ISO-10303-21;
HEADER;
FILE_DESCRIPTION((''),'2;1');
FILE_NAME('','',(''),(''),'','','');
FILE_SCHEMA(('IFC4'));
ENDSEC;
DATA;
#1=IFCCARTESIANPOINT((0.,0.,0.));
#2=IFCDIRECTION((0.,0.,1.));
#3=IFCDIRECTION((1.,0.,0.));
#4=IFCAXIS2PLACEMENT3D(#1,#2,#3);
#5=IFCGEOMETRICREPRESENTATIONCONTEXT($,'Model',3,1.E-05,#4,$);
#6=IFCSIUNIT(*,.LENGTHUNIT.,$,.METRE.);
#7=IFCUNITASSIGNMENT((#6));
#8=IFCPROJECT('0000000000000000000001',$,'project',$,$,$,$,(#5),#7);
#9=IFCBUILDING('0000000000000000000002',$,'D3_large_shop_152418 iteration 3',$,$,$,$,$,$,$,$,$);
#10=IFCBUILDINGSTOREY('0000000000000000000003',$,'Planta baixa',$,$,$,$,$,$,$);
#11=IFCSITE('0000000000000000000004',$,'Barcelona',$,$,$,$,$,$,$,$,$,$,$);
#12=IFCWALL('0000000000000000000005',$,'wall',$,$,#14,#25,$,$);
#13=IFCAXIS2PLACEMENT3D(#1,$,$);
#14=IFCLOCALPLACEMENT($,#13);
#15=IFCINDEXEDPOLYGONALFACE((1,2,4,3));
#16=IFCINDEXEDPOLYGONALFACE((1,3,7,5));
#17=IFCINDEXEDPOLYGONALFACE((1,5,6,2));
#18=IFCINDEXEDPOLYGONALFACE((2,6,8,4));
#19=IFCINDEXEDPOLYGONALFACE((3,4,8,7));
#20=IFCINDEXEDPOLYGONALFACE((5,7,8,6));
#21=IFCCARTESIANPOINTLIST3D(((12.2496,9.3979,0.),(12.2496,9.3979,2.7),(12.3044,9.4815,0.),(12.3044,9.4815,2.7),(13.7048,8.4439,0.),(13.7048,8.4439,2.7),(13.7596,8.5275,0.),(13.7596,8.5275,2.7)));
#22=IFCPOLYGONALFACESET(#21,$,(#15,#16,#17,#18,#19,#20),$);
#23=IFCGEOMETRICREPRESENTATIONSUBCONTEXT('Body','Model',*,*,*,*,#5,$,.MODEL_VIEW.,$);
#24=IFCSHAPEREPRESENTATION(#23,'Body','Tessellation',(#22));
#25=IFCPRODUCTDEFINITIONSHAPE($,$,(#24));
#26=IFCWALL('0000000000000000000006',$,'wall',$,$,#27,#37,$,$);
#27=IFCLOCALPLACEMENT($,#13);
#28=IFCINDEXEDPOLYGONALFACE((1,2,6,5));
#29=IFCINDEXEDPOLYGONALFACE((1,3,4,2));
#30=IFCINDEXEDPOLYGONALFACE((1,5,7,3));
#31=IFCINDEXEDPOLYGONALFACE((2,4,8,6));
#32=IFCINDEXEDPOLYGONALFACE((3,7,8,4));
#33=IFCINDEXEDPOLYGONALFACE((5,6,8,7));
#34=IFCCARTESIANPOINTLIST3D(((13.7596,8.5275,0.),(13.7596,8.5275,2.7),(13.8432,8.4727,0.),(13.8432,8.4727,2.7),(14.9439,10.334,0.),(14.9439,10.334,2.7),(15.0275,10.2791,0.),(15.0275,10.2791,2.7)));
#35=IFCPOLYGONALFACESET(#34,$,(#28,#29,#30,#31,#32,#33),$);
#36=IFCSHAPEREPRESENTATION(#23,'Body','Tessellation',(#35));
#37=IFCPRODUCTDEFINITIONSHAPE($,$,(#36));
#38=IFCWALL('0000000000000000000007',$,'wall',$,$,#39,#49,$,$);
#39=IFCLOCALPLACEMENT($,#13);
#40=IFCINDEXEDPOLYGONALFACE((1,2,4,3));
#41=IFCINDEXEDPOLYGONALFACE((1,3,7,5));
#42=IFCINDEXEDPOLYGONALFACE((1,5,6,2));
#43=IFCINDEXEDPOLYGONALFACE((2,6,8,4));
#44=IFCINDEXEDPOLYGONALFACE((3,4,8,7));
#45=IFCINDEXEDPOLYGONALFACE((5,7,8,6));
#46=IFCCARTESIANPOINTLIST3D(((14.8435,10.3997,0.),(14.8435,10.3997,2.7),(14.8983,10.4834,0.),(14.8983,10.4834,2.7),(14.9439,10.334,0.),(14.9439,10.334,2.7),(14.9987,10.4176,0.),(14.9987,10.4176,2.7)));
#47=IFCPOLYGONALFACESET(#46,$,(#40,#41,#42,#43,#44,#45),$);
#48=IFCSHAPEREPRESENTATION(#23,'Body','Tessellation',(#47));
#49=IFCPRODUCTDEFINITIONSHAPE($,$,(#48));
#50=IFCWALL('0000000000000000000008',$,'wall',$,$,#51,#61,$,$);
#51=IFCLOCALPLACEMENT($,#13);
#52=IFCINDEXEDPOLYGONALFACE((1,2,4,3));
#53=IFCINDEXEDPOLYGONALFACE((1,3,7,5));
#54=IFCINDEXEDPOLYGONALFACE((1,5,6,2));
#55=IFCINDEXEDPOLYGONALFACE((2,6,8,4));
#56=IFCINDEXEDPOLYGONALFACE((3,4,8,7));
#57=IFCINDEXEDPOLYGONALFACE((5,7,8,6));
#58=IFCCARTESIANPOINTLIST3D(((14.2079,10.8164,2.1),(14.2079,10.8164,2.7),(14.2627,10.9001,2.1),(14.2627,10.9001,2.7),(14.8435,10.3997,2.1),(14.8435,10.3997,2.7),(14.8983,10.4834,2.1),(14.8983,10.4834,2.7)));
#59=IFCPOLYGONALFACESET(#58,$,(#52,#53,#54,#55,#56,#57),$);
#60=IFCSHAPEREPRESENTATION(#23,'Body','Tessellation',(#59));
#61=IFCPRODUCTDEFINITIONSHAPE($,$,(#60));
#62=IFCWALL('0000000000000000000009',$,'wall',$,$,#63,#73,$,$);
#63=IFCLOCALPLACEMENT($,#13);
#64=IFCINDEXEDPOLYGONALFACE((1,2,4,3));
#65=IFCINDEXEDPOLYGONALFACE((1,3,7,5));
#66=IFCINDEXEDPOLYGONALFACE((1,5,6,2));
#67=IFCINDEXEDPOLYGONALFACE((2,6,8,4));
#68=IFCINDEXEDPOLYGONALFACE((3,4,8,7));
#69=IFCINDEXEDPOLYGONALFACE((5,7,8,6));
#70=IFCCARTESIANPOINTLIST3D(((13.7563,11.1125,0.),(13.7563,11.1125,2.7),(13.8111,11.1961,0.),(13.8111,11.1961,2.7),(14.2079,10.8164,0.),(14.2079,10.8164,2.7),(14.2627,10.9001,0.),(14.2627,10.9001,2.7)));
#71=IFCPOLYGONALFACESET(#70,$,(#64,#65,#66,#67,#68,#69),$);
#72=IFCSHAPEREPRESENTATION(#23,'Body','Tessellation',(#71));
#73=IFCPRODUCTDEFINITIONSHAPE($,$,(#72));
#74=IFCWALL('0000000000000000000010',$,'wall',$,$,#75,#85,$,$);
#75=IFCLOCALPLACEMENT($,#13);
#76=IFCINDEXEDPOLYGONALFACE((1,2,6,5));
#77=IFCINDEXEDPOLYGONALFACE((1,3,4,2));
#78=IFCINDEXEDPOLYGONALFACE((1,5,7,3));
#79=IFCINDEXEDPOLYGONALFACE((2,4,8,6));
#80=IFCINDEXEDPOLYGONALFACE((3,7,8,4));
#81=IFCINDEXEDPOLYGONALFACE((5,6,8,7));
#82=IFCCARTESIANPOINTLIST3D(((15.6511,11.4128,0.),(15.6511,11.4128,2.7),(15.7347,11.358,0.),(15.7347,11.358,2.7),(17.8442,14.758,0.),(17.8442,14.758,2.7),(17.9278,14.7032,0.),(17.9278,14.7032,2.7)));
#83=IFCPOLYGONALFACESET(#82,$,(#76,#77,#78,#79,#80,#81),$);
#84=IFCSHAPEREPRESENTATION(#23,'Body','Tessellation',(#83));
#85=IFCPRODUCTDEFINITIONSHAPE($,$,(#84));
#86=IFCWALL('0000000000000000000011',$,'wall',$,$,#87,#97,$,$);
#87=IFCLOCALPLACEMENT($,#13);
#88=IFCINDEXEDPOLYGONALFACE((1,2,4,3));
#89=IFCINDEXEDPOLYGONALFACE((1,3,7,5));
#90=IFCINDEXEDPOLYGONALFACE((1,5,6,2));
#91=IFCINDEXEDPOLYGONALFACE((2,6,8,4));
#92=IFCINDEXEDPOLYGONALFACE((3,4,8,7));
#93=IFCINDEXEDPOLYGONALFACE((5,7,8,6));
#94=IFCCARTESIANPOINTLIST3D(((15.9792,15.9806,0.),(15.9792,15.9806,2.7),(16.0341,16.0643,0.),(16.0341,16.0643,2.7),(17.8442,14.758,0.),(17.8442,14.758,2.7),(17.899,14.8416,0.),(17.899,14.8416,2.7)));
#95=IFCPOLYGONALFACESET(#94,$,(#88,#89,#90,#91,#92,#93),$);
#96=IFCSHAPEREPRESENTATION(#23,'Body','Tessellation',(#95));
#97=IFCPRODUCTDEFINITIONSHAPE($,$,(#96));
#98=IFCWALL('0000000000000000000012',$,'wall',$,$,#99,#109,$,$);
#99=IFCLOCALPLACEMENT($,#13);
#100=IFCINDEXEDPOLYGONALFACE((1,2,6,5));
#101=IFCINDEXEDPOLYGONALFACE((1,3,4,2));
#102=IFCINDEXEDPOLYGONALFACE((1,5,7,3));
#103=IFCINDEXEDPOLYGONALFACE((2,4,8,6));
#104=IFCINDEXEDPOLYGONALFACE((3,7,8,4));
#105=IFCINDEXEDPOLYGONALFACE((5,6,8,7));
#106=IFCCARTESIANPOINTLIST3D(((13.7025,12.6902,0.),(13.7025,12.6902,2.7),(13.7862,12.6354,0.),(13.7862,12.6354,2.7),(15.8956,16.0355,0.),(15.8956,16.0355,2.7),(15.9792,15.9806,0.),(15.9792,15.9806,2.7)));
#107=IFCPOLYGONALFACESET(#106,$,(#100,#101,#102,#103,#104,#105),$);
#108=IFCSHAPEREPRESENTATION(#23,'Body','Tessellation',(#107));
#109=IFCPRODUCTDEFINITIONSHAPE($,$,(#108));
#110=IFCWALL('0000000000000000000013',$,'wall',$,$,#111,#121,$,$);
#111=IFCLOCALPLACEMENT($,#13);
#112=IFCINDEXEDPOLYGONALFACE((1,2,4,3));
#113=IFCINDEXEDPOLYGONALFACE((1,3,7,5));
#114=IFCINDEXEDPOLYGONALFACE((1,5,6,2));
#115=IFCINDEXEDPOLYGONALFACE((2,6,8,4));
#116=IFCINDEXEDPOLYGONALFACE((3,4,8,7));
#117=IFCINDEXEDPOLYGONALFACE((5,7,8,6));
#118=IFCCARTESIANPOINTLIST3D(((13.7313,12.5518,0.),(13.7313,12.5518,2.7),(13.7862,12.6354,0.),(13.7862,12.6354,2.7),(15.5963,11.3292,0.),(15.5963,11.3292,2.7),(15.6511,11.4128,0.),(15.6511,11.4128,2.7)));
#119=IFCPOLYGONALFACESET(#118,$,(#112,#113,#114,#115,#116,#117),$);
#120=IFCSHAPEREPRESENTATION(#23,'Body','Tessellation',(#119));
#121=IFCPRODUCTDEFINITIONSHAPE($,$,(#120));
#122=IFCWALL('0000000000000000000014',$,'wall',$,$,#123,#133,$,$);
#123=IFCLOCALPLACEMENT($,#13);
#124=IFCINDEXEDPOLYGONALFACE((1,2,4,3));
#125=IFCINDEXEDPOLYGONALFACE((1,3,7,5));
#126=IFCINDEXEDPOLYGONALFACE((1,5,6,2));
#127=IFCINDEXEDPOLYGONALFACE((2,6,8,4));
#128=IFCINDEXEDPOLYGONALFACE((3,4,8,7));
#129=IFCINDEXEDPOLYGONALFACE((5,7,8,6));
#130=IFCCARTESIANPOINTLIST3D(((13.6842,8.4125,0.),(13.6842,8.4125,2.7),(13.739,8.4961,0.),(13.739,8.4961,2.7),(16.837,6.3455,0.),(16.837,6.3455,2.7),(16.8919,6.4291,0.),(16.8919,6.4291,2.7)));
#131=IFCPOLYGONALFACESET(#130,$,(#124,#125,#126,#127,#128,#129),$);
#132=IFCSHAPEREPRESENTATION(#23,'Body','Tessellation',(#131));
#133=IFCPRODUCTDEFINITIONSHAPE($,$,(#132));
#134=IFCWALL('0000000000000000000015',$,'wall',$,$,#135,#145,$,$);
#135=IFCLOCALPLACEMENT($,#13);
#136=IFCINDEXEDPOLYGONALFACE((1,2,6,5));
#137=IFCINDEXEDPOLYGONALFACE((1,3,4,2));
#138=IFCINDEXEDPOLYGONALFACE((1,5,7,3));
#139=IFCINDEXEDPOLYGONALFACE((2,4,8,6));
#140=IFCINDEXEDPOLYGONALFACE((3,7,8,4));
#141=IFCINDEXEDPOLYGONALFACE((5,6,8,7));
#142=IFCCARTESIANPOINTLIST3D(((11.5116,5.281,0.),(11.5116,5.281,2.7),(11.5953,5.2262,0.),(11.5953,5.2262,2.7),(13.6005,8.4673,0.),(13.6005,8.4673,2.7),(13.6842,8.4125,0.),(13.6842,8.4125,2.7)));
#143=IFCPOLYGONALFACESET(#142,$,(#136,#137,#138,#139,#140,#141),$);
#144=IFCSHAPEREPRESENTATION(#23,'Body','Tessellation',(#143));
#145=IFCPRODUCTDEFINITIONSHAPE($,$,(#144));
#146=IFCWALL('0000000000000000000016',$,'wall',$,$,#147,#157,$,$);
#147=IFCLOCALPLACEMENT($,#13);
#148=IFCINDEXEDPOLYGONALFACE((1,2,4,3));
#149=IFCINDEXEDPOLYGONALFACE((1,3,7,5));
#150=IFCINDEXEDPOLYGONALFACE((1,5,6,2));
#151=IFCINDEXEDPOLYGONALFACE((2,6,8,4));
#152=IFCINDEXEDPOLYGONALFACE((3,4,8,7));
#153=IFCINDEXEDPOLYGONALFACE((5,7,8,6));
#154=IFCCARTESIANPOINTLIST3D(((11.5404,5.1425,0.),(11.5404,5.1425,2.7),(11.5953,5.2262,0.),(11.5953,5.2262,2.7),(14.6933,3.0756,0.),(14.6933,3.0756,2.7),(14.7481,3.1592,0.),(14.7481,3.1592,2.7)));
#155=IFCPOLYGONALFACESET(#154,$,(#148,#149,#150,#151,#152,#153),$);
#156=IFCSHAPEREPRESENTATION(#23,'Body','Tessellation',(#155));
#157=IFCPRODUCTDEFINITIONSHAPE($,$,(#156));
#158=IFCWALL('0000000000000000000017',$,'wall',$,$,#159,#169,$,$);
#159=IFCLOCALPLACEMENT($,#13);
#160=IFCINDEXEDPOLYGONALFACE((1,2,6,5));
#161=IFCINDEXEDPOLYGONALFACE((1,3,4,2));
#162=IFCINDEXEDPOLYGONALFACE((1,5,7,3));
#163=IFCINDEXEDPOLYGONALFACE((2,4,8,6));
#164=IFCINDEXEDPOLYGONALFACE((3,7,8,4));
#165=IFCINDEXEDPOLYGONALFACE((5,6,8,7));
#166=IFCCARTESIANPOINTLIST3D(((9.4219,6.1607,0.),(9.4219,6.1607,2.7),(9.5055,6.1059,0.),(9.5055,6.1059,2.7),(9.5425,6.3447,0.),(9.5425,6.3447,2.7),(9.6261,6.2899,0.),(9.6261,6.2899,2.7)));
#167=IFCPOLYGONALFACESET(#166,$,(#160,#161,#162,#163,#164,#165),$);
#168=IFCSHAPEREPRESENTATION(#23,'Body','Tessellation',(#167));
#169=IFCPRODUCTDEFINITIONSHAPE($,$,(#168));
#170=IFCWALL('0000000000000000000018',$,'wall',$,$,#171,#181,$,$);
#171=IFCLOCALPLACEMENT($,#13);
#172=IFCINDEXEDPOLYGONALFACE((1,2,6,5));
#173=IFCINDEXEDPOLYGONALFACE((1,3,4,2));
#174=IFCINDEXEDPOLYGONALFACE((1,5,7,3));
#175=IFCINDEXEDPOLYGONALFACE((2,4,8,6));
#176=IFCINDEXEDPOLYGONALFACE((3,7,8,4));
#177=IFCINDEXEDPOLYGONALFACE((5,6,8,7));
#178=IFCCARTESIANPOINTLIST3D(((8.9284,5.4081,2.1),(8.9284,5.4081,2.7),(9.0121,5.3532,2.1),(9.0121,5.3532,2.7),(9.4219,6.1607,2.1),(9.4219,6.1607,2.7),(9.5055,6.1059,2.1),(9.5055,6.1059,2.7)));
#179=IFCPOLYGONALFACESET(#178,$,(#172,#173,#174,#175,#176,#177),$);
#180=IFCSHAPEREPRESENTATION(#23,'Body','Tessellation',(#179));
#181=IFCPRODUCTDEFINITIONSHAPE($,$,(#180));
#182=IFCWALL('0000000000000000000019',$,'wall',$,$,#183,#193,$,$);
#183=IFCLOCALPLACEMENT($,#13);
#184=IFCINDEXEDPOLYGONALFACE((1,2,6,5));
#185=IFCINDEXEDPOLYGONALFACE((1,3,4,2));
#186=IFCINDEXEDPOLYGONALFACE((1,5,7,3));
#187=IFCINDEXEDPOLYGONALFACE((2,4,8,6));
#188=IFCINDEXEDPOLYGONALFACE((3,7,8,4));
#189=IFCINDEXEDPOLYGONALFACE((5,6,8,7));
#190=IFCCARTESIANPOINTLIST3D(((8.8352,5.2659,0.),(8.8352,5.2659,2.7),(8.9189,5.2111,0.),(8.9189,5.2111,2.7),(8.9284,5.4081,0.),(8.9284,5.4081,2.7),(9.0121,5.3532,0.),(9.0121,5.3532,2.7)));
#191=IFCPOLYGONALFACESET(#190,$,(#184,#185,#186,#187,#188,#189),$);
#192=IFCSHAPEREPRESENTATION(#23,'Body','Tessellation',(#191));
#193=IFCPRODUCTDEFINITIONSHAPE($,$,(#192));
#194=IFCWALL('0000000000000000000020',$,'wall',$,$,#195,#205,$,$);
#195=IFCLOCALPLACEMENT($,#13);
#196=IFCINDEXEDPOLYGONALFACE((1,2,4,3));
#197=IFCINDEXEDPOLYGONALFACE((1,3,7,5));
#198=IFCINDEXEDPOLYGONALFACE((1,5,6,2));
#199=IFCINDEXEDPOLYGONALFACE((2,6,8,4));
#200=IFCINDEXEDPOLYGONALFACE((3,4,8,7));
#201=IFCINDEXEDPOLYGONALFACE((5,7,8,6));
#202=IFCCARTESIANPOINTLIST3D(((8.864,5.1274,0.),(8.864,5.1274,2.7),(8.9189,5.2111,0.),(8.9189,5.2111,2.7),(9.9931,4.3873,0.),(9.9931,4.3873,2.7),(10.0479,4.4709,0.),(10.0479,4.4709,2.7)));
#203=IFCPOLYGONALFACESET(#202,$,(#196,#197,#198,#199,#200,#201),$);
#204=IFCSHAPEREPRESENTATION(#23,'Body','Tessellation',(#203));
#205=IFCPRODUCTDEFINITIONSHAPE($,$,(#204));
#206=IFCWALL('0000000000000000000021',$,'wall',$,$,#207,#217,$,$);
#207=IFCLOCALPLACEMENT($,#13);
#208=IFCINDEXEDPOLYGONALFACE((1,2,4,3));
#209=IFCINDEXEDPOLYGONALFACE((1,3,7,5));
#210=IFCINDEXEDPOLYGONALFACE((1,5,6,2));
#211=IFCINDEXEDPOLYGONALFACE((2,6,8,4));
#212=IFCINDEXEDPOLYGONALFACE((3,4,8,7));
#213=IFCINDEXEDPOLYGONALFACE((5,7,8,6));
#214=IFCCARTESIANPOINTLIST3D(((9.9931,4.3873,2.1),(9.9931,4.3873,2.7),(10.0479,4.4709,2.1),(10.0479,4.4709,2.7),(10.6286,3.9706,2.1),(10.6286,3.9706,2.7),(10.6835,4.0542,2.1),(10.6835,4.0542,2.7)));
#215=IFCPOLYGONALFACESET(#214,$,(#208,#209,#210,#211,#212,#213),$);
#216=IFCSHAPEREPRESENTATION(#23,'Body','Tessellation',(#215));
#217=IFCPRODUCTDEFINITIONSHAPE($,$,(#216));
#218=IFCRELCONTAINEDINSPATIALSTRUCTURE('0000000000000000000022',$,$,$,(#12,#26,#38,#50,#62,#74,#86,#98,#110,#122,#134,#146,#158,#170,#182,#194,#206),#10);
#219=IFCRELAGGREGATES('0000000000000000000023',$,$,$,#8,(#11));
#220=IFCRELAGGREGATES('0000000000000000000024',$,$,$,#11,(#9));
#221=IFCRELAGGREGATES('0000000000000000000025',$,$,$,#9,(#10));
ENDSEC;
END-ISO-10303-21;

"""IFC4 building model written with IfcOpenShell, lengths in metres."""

from ifc_helpers import new_model, si_unit, frame, origin, origin_with_axes, place, context, subcontext, project, spatial, polyline, outline, extrude, element, save


model = new_model("IFC4")

# Units and contexts
model_context = context("Model", 3, precision=1e-05, world=origin_with_axes())
body_context = subcontext(model_context, "Body", "Model", "MODEL_VIEW")
ifc_project = project(units=[si_unit("LENGTHUNIT", "METRE")], contexts=[model_context])

# Site, building, storey
site = spatial("IfcSite", under=ifc_project, Name="Barcelona")
building = spatial("IfcBuilding", under=site, Name="D3_large_shop_152418 iteration 3")
storey = spatial("IfcBuildingStorey", under=building, Name="Planta baixa")

# Walls
wall_1_placement = place(None, origin_with_axes())
element("IfcWall", 1, at=wall_1_placement, inside=storey, Name="wall", context=body_context, shape_type="SweptSolid", body=[
    extrude(outline(polyline([(12.3044, 9.4815), (13.7596, 8.5275), (13.7048, 8.4439), (12.2496, 9.3979), (12.3044, 9.4815)])), origin(), (0.0, 0.0, 1.0), 2.7),
])
wall_2_placement = place(None, origin_with_axes())
element("IfcWall", 2, at=wall_2_placement, inside=storey, Name="wall", context=body_context, shape_type="SweptSolid", body=[
    extrude(outline(polyline([(13.7596, 8.5275), (14.9439, 10.334), (15.0275, 10.2791), (13.8432, 8.4727), (13.7596, 8.5275)])), origin(), (0.0, 0.0, 1.0), 2.7),
])
wall_3_placement = place(None, origin_with_axes())
element("IfcWall", 3, at=wall_3_placement, inside=storey, Name="wall", context=body_context, shape_type="SweptSolid", body=[
    extrude(outline(polyline([(14.9439, 10.334), (14.8435, 10.3997), (14.8983, 10.4834), (14.9987, 10.4176), (14.9439, 10.334)])), origin(), (0.0, 0.0, 1.0), 2.7),
])
wall_4_placement = place(None, origin_with_axes())
element("IfcWall", 4, at=wall_4_placement, inside=storey, Name="wall", context=body_context, shape_type="SweptSolid", body=[
    extrude(outline(polyline([(14.8435, 10.3997), (14.2079, 10.8164), (14.2627, 10.9001), (14.8983, 10.4834), (14.8435, 10.3997)])), frame((0.0, 0.0, 2.1)), (0.0, 0.0, 1.0), 0.6),
])
wall_5_placement = place(None, origin_with_axes())
element("IfcWall", 5, at=wall_5_placement, inside=storey, Name="wall", context=body_context, shape_type="SweptSolid", body=[
    extrude(outline(polyline([(14.2079, 10.8164), (13.7563, 11.1125), (13.8111, 11.1961), (14.2627, 10.9001), (14.2079, 10.8164)])), origin(), (0.0, 0.0, 1.0), 2.7),
])
wall_6_placement = place(None, origin_with_axes())
element("IfcWall", 6, at=wall_6_placement, inside=storey, Name="wall", context=body_context, shape_type="SweptSolid", body=[
    extrude(outline(polyline([(15.6511, 11.4128), (17.8442, 14.758), (17.9278, 14.7032), (15.7347, 11.358), (15.6511, 11.4128)])), origin(), (0.0, 0.0, 1.0), 2.7),
])
wall_7_placement = place(None, origin_with_axes())
element("IfcWall", 7, at=wall_7_placement, inside=storey, Name="wall", context=body_context, shape_type="SweptSolid", body=[
    extrude(outline(polyline([(17.8442, 14.758), (15.9792, 15.9806), (16.0341, 16.0643), (17.899, 14.8416), (17.8442, 14.758)])), origin(), (0.0, 0.0, 1.0), 2.7),
])
wall_8_placement = place(None, origin_with_axes())
element("IfcWall", 8, at=wall_8_placement, inside=storey, Name="wall", context=body_context, shape_type="SweptSolid", body=[
    extrude(outline(polyline([(15.9792, 15.9806), (13.7862, 12.6354), (13.7025, 12.6902), (15.8956, 16.0355), (15.9792, 15.9806)])), origin(), (0.0, 0.0, 1.0), 2.7),
])
wall_9_placement = place(None, origin_with_axes())
element("IfcWall", 9, at=wall_9_placement, inside=storey, Name="wall", context=body_context, shape_type="SweptSolid", body=[
    extrude(outline(polyline([(13.7862, 12.6354), (15.6511, 11.4128), (15.5963, 11.3292), (13.7313, 12.5518), (13.7862, 12.6354)])), origin(), (0.0, 0.0, 1.0), 2.7),
])
wall_10_placement = place(None, origin_with_axes())
element("IfcWall", 10, at=wall_10_placement, inside=storey, Name="wall", context=body_context, shape_type="SweptSolid", body=[
    extrude(outline(polyline([(16.837, 6.3455), (13.6842, 8.4125), (13.739, 8.4961), (16.8919, 6.4291), (16.837, 6.3455)])), origin(), (0.0, 0.0, 1.0), 2.7),
])
wall_11_placement = place(None, origin_with_axes())
element("IfcWall", 11, at=wall_11_placement, inside=storey, Name="wall", context=body_context, shape_type="SweptSolid", body=[
    extrude(outline(polyline([(13.6842, 8.4125), (11.5953, 5.2262), (11.5116, 5.281), (13.6005, 8.4673), (13.6842, 8.4125)])), origin(), (0.0, 0.0, 1.0), 2.7),
])
wall_12_placement = place(None, origin_with_axes())
element("IfcWall", 12, at=wall_12_placement, inside=storey, Name="wall", context=body_context, shape_type="SweptSolid", body=[
    extrude(outline(polyline([(11.5953, 5.2262), (14.7481, 3.1592), (14.6933, 3.0756), (11.5404, 5.1425), (11.5953, 5.2262)])), origin(), (0.0, 0.0, 1.0), 2.7),
])
wall_13_placement = place(None, origin_with_axes())
element("IfcWall", 13, at=wall_13_placement, inside=storey, Name="wall", context=body_context, shape_type="SweptSolid", body=[
    extrude(outline(polyline([(9.6261, 6.2899), (9.5055, 6.1059), (9.4219, 6.1607), (9.5425, 6.3447), (9.6261, 6.2899)])), origin(), (0.0, 0.0, 1.0), 2.7),
])
wall_14_placement = place(None, origin_with_axes())
element("IfcWall", 14, at=wall_14_placement, inside=storey, Name="wall", context=body_context, shape_type="SweptSolid", body=[
    extrude(outline(polyline([(9.5055, 6.1059), (9.0121, 5.3532), (8.9284, 5.4081), (9.4219, 6.1607), (9.5055, 6.1059)])), frame((0.0, 0.0, 2.1)), (0.0, 0.0, 1.0), 0.6),
])
wall_15_placement = place(None, origin_with_axes())
element("IfcWall", 15, at=wall_15_placement, inside=storey, Name="wall", context=body_context, shape_type="SweptSolid", body=[
    extrude(outline(polyline([(9.0121, 5.3532), (8.9189, 5.2111), (8.8352, 5.2659), (8.9284, 5.4081), (9.0121, 5.3532)])), origin(), (0.0, 0.0, 1.0), 2.7),
])
wall_16_placement = place(None, origin_with_axes())
element("IfcWall", 16, at=wall_16_placement, inside=storey, Name="wall", context=body_context, shape_type="SweptSolid", body=[
    extrude(outline(polyline([(8.9189, 5.2111), (10.0479, 4.4709), (9.9931, 4.3873), (8.864, 5.1274), (8.9189, 5.2111)])), origin(), (0.0, 0.0, 1.0), 2.7),
])
wall_17_placement = place(None, origin_with_axes())
element("IfcWall", 17, at=wall_17_placement, inside=storey, Name="wall", context=body_context, shape_type="SweptSolid", body=[
    extrude(outline(polyline([(10.0479, 4.4709), (10.6835, 4.0542), (10.6286, 3.9706), (9.9931, 4.3873), (10.0479, 4.4709)])), frame((0.0, 0.0, 2.1)), (0.0, 0.0, 1.0), 0.6),
])

save(model, "model.ifc")
